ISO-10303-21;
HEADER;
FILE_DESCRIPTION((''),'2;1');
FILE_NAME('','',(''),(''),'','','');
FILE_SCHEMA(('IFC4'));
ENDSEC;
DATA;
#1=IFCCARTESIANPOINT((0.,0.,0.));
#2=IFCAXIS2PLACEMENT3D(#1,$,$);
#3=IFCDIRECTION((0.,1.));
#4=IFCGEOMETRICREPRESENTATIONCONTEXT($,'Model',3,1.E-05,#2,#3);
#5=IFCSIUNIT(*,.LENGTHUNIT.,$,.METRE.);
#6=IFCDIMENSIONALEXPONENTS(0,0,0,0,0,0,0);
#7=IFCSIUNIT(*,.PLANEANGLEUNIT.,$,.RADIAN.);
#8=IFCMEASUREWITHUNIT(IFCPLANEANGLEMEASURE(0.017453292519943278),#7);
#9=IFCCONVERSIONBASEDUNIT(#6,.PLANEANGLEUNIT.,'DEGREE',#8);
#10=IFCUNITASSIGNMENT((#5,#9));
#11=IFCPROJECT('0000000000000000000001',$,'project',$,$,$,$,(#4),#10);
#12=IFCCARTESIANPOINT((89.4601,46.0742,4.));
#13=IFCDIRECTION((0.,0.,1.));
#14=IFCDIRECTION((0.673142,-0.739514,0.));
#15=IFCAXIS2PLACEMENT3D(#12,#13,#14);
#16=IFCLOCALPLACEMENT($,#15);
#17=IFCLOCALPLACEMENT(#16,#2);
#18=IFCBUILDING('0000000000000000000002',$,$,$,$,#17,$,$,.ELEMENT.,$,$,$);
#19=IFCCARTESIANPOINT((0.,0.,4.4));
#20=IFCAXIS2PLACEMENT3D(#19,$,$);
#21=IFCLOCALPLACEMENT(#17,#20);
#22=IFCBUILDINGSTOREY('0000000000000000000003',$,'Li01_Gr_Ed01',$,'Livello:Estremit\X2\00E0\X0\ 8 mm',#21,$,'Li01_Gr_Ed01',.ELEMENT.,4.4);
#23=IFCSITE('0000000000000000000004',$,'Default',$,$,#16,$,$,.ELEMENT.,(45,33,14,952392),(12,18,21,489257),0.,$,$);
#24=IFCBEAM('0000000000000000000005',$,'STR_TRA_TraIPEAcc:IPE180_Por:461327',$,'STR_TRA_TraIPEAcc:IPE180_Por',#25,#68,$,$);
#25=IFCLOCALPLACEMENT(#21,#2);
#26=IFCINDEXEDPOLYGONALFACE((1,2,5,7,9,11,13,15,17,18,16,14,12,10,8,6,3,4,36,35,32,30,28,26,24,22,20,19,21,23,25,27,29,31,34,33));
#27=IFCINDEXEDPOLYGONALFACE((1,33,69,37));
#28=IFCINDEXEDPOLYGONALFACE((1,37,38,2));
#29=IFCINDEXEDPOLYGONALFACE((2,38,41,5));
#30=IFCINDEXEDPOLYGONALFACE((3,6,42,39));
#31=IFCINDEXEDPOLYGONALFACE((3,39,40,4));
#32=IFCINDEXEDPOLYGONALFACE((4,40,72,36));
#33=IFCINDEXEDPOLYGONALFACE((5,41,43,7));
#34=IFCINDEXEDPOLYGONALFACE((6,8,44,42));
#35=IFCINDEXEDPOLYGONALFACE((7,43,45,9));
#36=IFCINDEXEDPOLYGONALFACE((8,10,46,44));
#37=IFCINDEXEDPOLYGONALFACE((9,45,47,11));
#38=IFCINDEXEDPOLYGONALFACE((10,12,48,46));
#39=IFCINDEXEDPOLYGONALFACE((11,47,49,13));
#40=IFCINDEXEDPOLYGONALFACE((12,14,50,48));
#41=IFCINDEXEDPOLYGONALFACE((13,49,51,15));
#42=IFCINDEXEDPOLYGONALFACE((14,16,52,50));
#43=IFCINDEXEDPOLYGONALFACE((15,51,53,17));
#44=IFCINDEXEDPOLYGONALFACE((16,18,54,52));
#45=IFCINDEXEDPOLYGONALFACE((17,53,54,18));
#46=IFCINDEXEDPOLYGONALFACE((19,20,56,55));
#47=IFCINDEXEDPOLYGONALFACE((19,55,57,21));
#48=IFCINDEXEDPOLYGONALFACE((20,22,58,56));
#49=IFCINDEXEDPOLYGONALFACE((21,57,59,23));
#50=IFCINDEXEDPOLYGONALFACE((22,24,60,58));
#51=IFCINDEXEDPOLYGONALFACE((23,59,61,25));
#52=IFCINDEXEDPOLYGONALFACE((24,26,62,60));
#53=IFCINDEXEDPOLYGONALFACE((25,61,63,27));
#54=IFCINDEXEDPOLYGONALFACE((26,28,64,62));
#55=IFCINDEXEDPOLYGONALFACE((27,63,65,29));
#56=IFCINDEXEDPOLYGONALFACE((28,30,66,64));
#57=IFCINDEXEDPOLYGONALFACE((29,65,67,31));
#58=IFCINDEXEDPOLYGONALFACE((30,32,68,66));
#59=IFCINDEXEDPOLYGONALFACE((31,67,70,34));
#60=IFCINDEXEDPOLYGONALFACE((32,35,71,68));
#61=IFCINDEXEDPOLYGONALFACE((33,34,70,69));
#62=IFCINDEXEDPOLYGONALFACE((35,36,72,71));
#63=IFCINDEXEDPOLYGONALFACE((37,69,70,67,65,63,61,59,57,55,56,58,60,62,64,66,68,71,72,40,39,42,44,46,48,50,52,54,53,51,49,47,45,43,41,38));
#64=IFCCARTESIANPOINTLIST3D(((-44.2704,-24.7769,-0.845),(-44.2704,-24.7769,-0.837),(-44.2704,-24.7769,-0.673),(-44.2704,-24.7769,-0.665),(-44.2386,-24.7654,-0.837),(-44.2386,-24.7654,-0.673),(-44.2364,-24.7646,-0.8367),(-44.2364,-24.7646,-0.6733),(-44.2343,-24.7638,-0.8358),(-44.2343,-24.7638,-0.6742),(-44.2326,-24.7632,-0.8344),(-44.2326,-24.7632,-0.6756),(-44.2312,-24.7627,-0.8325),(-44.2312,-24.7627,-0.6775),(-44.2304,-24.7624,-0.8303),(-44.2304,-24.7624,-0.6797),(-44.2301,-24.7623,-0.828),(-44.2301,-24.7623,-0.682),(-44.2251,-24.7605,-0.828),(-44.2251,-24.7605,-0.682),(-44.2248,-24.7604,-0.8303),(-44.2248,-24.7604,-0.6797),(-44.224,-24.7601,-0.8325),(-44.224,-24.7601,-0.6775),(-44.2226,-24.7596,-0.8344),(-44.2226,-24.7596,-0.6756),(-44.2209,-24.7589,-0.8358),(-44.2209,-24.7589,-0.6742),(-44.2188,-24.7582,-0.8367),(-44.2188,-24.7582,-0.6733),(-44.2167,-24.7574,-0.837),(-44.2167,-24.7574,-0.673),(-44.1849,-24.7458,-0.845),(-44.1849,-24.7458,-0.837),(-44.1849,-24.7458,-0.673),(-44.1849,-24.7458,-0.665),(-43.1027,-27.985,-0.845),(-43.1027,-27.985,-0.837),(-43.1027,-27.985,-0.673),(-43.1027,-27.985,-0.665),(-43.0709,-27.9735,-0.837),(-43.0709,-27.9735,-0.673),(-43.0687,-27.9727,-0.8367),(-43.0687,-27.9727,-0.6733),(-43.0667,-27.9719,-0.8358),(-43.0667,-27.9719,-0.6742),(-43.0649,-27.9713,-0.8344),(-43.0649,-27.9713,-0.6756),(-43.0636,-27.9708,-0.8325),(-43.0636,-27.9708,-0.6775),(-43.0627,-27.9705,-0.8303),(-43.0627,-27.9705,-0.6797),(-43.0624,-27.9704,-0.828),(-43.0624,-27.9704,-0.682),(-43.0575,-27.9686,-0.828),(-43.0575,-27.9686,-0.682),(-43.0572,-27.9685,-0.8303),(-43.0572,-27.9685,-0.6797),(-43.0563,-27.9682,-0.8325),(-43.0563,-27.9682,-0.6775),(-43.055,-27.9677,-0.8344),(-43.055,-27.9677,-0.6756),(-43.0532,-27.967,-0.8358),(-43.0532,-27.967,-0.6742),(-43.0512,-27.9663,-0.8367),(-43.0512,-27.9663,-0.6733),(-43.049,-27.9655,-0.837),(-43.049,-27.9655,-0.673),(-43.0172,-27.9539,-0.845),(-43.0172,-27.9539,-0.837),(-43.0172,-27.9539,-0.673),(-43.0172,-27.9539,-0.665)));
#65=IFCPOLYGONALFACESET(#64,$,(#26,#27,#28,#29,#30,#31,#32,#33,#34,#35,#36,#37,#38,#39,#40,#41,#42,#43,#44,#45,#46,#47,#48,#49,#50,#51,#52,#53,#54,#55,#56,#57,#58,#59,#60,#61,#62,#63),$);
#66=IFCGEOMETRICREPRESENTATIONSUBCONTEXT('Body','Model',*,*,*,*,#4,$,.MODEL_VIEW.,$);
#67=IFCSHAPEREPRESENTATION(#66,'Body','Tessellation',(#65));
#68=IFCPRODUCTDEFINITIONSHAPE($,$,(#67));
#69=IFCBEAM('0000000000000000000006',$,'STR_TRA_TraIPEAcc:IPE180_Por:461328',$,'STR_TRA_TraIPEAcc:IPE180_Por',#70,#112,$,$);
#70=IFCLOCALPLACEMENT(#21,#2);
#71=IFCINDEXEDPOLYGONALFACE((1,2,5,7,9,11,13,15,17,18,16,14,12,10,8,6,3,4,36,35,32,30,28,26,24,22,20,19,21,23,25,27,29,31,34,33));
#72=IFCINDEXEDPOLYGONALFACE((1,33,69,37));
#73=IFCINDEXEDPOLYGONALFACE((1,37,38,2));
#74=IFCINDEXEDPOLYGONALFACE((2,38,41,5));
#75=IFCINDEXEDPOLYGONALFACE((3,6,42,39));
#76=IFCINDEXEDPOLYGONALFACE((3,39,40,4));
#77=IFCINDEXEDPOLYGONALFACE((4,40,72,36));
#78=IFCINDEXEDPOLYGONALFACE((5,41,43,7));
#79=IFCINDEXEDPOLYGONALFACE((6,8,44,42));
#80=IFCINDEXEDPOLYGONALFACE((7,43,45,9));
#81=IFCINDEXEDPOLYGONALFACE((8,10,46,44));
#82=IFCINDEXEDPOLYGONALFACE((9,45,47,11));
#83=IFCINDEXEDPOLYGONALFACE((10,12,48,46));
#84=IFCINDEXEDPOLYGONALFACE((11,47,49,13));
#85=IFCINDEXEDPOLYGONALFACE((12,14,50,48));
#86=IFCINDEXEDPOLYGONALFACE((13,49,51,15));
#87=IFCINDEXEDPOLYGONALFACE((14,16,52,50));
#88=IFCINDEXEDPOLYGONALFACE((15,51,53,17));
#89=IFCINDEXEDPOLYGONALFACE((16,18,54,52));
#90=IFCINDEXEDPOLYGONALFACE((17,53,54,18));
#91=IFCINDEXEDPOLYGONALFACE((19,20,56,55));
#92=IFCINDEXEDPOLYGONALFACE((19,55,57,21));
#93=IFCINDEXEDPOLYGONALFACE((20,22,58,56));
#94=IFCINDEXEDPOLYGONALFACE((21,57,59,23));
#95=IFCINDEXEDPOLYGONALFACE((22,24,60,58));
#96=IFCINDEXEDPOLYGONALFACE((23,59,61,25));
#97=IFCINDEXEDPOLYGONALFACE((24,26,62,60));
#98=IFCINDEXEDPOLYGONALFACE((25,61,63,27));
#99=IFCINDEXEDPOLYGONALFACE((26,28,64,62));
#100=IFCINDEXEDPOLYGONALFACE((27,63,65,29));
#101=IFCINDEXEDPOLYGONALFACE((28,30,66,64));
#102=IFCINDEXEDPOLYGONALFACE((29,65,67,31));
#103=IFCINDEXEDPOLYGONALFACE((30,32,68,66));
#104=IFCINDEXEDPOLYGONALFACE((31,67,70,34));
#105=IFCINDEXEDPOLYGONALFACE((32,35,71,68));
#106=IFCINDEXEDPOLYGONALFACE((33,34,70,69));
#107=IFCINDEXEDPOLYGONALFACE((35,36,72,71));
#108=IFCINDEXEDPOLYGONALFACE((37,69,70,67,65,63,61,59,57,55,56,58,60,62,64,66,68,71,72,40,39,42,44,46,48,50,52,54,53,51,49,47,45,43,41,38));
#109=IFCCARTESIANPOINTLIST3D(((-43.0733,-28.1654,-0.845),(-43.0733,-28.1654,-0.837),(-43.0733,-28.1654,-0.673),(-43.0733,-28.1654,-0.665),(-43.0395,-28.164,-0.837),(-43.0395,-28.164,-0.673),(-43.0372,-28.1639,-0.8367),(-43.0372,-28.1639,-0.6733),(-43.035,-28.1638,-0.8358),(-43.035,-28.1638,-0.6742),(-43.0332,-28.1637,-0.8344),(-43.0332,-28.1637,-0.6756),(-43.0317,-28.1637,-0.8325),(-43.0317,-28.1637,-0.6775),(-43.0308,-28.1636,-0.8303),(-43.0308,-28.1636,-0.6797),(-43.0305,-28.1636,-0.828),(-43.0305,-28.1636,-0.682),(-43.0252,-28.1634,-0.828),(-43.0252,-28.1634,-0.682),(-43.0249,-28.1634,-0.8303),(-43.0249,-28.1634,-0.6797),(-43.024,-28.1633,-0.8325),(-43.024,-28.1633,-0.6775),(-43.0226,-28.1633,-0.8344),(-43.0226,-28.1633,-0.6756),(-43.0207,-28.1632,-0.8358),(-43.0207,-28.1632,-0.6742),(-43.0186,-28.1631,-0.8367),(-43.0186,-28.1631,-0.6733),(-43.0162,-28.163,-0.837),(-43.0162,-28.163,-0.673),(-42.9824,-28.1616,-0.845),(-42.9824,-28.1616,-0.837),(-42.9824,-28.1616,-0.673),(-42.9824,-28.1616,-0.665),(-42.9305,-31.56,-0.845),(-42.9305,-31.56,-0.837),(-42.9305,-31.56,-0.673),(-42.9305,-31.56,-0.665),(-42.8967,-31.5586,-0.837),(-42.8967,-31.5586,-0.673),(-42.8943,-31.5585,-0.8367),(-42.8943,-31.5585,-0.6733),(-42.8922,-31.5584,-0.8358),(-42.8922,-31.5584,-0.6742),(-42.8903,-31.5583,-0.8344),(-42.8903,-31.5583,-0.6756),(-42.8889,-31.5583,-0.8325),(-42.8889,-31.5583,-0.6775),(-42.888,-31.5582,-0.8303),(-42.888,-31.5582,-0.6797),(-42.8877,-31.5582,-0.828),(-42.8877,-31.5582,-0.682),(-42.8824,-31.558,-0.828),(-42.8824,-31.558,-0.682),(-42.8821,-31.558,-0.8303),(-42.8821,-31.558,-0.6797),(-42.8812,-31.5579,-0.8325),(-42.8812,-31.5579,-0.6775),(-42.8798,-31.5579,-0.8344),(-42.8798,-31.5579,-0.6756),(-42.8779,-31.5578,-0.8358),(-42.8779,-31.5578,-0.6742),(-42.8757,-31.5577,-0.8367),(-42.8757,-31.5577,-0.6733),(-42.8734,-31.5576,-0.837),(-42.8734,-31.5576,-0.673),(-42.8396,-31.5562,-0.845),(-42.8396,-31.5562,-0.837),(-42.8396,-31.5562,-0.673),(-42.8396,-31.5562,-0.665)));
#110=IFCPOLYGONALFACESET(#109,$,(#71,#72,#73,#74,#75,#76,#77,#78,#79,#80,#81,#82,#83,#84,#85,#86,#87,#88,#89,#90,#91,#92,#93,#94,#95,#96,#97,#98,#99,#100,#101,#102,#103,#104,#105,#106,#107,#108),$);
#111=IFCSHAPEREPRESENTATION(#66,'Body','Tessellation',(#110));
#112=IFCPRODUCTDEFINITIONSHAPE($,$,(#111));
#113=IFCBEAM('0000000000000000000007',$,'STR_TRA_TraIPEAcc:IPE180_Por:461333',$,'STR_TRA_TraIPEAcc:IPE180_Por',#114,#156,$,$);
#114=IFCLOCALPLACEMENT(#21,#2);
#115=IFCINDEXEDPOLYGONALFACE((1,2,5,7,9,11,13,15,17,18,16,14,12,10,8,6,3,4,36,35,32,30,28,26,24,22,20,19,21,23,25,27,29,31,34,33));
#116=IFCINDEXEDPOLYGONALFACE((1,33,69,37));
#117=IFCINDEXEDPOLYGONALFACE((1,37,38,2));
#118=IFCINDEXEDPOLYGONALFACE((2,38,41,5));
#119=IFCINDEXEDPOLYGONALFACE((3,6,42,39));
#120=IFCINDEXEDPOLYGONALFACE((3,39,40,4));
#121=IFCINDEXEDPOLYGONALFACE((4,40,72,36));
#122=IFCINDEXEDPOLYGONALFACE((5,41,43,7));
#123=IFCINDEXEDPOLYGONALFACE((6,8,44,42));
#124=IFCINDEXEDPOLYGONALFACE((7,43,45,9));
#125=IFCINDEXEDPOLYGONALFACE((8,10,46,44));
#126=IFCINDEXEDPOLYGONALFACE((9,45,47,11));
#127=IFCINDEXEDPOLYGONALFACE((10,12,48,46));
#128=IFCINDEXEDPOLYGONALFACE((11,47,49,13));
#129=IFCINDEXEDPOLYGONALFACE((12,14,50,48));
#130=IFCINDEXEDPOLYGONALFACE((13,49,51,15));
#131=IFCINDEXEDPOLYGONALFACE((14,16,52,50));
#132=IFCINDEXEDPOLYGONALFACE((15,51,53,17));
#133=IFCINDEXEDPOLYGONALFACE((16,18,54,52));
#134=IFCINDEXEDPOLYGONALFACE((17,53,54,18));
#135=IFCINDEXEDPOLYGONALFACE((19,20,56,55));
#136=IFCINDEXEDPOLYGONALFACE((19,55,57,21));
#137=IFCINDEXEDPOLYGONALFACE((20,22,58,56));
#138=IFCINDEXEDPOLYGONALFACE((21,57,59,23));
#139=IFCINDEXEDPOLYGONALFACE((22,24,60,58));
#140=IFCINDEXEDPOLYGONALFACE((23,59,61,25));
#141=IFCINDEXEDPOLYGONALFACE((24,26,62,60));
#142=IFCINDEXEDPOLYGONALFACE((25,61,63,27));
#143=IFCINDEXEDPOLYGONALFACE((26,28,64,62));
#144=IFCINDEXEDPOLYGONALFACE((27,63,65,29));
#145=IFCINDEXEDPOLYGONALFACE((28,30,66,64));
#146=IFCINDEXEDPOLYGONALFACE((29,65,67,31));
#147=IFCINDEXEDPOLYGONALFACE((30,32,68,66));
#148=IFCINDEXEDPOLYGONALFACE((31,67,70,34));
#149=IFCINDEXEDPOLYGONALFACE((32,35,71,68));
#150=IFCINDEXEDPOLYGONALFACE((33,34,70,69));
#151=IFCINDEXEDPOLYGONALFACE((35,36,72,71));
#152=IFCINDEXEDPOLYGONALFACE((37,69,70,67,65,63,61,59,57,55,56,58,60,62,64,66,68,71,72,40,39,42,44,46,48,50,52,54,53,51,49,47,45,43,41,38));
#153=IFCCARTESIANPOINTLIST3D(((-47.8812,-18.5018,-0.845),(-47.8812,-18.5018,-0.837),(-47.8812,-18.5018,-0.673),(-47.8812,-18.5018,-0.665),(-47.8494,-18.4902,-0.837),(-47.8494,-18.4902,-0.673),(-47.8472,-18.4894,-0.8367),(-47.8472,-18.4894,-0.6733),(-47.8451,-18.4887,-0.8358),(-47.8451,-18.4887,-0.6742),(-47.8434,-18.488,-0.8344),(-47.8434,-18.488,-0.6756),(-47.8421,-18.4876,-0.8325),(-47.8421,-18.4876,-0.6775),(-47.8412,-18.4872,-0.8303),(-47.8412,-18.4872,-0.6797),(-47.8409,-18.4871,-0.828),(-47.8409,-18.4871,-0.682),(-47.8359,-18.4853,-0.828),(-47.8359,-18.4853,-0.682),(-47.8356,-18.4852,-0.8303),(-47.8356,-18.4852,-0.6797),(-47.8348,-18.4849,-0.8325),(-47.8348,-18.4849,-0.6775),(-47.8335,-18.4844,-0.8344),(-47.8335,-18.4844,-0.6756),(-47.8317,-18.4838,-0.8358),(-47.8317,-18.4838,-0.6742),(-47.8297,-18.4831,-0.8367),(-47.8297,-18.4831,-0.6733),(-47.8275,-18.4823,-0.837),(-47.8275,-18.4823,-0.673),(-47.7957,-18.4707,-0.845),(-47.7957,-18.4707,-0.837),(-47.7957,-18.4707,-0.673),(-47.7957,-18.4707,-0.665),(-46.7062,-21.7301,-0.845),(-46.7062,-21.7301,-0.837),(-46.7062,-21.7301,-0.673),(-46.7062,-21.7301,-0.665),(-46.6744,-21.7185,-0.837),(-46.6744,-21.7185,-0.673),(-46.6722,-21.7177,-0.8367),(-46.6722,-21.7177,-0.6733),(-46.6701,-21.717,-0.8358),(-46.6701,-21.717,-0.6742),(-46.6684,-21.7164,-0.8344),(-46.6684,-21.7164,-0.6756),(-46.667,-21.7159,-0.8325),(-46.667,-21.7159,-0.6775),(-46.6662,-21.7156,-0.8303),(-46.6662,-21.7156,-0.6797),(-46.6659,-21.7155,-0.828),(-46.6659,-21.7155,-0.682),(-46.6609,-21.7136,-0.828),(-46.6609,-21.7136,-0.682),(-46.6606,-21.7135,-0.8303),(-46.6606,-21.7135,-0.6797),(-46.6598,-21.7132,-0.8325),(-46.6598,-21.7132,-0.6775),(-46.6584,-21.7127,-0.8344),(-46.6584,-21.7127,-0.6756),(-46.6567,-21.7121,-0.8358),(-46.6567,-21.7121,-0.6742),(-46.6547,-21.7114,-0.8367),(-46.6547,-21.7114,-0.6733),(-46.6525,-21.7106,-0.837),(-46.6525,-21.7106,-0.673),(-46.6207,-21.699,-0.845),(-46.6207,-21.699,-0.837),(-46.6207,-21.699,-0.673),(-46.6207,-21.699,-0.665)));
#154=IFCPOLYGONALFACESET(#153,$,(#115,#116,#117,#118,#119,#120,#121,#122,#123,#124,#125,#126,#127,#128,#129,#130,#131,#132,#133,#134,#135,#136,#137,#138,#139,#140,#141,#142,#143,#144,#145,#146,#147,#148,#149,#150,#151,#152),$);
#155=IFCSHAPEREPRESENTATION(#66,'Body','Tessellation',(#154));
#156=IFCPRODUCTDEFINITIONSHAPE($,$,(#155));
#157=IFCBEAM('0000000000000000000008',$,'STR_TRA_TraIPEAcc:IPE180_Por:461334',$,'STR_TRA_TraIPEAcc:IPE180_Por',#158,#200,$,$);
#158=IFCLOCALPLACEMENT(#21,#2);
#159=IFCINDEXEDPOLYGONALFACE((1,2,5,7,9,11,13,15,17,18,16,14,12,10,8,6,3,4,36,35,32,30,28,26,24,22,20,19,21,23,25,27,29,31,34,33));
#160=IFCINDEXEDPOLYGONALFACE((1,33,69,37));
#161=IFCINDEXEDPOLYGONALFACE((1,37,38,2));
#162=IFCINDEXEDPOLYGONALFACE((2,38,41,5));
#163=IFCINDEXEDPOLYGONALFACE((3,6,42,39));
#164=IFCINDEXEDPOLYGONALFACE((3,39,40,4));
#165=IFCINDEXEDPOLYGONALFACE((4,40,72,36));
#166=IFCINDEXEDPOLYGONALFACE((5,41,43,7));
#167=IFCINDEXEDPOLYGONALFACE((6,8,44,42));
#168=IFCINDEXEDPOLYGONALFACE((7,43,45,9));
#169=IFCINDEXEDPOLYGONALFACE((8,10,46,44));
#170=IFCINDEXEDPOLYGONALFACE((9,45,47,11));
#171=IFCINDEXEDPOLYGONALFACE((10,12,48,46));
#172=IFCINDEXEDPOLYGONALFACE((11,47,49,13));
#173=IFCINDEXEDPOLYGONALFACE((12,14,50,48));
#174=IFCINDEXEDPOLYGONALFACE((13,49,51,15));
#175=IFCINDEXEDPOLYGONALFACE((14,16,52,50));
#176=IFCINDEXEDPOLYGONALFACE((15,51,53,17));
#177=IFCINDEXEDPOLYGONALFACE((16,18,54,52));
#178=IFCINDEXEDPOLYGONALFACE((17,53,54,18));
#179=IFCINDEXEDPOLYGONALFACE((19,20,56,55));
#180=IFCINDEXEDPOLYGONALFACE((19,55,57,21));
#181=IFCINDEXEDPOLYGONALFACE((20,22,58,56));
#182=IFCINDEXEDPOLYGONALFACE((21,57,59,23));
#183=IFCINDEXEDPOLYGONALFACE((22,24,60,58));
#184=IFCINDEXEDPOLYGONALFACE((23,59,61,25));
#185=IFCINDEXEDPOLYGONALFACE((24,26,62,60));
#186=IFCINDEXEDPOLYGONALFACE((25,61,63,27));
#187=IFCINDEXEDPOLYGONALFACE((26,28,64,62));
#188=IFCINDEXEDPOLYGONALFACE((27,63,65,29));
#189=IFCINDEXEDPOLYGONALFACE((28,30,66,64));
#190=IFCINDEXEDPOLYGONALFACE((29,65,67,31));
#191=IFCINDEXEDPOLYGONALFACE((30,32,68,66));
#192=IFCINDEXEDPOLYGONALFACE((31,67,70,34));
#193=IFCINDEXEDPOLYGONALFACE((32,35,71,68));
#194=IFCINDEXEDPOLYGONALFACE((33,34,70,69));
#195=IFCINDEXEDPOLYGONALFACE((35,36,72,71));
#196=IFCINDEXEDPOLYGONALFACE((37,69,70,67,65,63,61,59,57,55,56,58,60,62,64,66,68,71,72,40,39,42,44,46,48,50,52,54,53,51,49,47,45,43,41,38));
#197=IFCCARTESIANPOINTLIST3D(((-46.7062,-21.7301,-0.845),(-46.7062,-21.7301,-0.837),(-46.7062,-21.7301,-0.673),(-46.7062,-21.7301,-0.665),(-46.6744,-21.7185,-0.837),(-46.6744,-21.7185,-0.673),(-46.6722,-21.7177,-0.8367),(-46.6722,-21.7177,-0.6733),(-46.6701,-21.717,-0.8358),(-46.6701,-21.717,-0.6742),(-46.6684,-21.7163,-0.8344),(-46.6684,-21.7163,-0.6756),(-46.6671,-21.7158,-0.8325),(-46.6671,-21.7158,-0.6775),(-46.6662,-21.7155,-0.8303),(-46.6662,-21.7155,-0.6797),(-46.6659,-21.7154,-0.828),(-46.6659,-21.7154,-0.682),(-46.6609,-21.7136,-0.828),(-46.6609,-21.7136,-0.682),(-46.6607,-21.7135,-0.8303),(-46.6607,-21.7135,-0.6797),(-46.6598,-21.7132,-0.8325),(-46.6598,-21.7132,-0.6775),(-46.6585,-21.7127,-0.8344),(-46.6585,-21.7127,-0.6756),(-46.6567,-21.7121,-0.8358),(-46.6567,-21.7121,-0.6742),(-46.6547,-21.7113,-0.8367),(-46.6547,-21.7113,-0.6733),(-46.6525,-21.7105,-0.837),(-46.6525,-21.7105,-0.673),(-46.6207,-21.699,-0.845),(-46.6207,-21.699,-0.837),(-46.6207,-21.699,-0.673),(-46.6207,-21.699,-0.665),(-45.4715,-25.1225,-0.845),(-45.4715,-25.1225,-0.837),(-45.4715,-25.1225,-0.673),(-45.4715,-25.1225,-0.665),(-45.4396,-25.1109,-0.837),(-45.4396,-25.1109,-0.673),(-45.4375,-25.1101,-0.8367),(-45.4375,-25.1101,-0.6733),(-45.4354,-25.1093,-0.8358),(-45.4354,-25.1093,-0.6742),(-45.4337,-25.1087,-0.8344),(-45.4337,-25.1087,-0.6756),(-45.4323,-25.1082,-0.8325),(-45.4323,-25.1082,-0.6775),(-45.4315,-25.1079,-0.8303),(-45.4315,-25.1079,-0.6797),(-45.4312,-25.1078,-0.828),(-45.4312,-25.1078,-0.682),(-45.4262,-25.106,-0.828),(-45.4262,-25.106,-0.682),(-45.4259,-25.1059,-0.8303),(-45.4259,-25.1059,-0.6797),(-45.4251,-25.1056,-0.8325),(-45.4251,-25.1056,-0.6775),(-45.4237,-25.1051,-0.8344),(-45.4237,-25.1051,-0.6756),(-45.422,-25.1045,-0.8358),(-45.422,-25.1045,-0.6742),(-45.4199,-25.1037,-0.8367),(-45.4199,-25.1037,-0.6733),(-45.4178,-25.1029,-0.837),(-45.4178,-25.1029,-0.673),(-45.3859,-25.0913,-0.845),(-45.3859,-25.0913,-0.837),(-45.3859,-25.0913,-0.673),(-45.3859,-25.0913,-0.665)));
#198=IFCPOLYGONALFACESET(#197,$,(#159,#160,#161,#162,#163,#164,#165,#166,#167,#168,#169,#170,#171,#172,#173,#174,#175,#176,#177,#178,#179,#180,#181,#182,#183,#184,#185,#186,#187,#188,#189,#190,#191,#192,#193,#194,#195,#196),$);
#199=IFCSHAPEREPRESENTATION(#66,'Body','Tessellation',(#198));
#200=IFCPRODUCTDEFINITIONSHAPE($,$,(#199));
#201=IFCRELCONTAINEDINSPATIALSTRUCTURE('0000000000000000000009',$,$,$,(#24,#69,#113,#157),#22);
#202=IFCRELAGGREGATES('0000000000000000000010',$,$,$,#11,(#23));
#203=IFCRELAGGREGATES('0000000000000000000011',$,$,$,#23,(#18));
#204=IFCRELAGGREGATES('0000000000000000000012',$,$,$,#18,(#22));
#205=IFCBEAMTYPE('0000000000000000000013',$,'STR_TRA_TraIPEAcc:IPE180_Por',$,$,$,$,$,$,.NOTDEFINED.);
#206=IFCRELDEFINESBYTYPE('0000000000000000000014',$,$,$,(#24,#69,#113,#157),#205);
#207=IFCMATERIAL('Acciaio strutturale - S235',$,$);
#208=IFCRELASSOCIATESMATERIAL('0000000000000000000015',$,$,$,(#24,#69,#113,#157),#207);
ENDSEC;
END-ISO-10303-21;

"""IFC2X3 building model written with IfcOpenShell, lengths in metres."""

from ifc_helpers import new_model, entity, si_unit, converted_unit, direction, frame, frame_2d, origin, place, context, subcontext, project, spatial, i_section, extrude, material, type_object, element, save


model = new_model("IFC2X3")

# Units and contexts
model_context = context("Model", 3, precision=1e-05, world=origin(), true_north=direction((0.0, 1.0)))
body_context = subcontext(model_context, "Body", "Model", "MODEL_VIEW")
ifc_project = project(units=[si_unit("LENGTHUNIT", "METRE"), converted_unit("PLANEANGLEUNIT", "DEGREE", entity("IfcPlaneAngleMeasure", 0.017453292519943278), si_unit("PLANEANGLEUNIT", "RADIAN"), dimensions=[0, 0, 0, 0, 0, 0, 0])], contexts=[model_context])

# Site, building, storey
site_placement = place(None, frame((89.4601, 46.0742, 4.0), z_axis=(0.0, 0.0, 1.0), x_axis=(0.673142, -0.739514, 0.0)))
site = spatial("IfcSite", under=ifc_project, at=site_placement, Name="Default", CompositionType="ELEMENT", RefLatitude=(45, 33, 14, 952392), RefLongitude=(12, 18, 21, 489257), RefElevation=0.0)
building_placement = place(site_placement, origin())
building = spatial("IfcBuilding", under=site, at=building_placement, CompositionType="ELEMENT")
storey_placement = place(building_placement, frame((0.0, 0.0, 4.4)))
storey = spatial("IfcBuildingStorey", under=building, at=storey_placement, Name="Li01_Gr_Ed01", ObjectType="Livello:Estremità 8 mm", LongName="Li01_Gr_Ed01", CompositionType="ELEMENT", Elevation=4.4)

# Beams
ifc_material_1 = material(Name="Acciaio strutturale - S235")
beam_type = type_object("IfcBeamType", Name="STR_TRA_TraIPEAcc:IPE180_Por", PredefinedType="NOTDEFINED")
beam_1_placement = place(storey_placement, frame((-44.2571, -24.6803, -0.665), z_axis=(0.0, 0.0, 1.0), x_axis=(0.34202, -0.939693, 0.0)))
element("IfcBeam", 1, at=beam_1_placement, inside=storey, type_object=beam_type, material=ifc_material_1, Name="STR_TRA_TraIPEAcc:IPE180_Por:461327", ObjectType="STR_TRA_TraIPEAcc:IPE180_Por", context=body_context, shape_type="SweptSolid", body=[
    extrude(i_section(OverallWidth=0.091, OverallDepth=0.18, WebThickness=0.0053, FlangeThickness=0.008, FilletRadius=0.009, at=frame_2d((0.0, 0.0), x_axis=(0.0, 1.0))), frame((0.0862, 0.0, -0.09), z_axis=(1.0, 0.0, 0.0), x_axis=(0.0, 0.0, -1.0)), (0.0, 0.0, 1.0), 3.414),
])
beam_2_placement = place(storey_placement, frame((-43.0284, -28.1507, -0.665), z_axis=(0.0, 0.0, 1.0), x_axis=(0.042041, -0.999116, 0.0)))
element("IfcBeam", 2, at=beam_2_placement, inside=storey, type_object=beam_type, material=ifc_material_1, Name="STR_TRA_TraIPEAcc:IPE180_Por:461328", ObjectType="STR_TRA_TraIPEAcc:IPE180_Por", context=body_context, shape_type="SweptSolid", body=[
    extrude(i_section(OverallWidth=0.091, OverallDepth=0.18, WebThickness=0.0053, FlangeThickness=0.008, FilletRadius=0.009, at=frame_2d((0.0, 0.0), x_axis=(0.0, 1.0))), frame((0.0128, 0.0, -0.09), z_axis=(1.0, 0.0, 0.0), x_axis=(0.0, 0.0, -1.0)), (0.0, 0.0, 1.0), 3.3976),
])
beam_3_placement = place(storey_placement, frame((-47.8457, -18.4664, -0.665), z_axis=(0.0, 0.0, 1.0), x_axis=(0.34202, -0.939693, 0.0)))
element("IfcBeam", 3, at=beam_3_placement, inside=storey, type_object=beam_type, material=ifc_material_1, Name="STR_TRA_TraIPEAcc:IPE180_Por:461333", ObjectType="STR_TRA_TraIPEAcc:IPE180_Por", context=body_context, shape_type="SweptSolid", body=[
    extrude(i_section(OverallWidth=0.091, OverallDepth=0.18, WebThickness=0.0053, FlangeThickness=0.008, FilletRadius=0.009, at=frame_2d((0.0, 0.0), x_axis=(0.0, 1.0))), frame((0.0211, 0.0, -0.09), z_axis=(1.0, 0.0, 0.0), x_axis=(0.0, 0.0, -1.0)), (0.0, 0.0, 1.0), 3.4355),
])
beam_4_placement = place(storey_placement, frame((-46.7116, -21.5823, -0.665), z_axis=(0.0, 0.0, 1.0), x_axis=(0.34202, -0.939693, 0.0)))
element("IfcBeam", 4, at=beam_4_placement, inside=storey, type_object=beam_type, material=ifc_material_1, Name="STR_TRA_TraIPEAcc:IPE180_Por:461334", ObjectType="STR_TRA_TraIPEAcc:IPE180_Por", context=body_context, shape_type="SweptSolid", body=[
    extrude(i_section(OverallWidth=0.091, OverallDepth=0.18, WebThickness=0.0053, FlangeThickness=0.008, FilletRadius=0.009, at=frame_2d((0.0, 0.0), x_axis=(0.0, 1.0))), frame((0.1407, 0.0, -0.09), z_axis=(1.0, 0.0, 0.0), x_axis=(0.0, 0.0, -1.0)), (0.0, 0.0, 1.0), 3.6101),
])

save(model, "model.ifc")
